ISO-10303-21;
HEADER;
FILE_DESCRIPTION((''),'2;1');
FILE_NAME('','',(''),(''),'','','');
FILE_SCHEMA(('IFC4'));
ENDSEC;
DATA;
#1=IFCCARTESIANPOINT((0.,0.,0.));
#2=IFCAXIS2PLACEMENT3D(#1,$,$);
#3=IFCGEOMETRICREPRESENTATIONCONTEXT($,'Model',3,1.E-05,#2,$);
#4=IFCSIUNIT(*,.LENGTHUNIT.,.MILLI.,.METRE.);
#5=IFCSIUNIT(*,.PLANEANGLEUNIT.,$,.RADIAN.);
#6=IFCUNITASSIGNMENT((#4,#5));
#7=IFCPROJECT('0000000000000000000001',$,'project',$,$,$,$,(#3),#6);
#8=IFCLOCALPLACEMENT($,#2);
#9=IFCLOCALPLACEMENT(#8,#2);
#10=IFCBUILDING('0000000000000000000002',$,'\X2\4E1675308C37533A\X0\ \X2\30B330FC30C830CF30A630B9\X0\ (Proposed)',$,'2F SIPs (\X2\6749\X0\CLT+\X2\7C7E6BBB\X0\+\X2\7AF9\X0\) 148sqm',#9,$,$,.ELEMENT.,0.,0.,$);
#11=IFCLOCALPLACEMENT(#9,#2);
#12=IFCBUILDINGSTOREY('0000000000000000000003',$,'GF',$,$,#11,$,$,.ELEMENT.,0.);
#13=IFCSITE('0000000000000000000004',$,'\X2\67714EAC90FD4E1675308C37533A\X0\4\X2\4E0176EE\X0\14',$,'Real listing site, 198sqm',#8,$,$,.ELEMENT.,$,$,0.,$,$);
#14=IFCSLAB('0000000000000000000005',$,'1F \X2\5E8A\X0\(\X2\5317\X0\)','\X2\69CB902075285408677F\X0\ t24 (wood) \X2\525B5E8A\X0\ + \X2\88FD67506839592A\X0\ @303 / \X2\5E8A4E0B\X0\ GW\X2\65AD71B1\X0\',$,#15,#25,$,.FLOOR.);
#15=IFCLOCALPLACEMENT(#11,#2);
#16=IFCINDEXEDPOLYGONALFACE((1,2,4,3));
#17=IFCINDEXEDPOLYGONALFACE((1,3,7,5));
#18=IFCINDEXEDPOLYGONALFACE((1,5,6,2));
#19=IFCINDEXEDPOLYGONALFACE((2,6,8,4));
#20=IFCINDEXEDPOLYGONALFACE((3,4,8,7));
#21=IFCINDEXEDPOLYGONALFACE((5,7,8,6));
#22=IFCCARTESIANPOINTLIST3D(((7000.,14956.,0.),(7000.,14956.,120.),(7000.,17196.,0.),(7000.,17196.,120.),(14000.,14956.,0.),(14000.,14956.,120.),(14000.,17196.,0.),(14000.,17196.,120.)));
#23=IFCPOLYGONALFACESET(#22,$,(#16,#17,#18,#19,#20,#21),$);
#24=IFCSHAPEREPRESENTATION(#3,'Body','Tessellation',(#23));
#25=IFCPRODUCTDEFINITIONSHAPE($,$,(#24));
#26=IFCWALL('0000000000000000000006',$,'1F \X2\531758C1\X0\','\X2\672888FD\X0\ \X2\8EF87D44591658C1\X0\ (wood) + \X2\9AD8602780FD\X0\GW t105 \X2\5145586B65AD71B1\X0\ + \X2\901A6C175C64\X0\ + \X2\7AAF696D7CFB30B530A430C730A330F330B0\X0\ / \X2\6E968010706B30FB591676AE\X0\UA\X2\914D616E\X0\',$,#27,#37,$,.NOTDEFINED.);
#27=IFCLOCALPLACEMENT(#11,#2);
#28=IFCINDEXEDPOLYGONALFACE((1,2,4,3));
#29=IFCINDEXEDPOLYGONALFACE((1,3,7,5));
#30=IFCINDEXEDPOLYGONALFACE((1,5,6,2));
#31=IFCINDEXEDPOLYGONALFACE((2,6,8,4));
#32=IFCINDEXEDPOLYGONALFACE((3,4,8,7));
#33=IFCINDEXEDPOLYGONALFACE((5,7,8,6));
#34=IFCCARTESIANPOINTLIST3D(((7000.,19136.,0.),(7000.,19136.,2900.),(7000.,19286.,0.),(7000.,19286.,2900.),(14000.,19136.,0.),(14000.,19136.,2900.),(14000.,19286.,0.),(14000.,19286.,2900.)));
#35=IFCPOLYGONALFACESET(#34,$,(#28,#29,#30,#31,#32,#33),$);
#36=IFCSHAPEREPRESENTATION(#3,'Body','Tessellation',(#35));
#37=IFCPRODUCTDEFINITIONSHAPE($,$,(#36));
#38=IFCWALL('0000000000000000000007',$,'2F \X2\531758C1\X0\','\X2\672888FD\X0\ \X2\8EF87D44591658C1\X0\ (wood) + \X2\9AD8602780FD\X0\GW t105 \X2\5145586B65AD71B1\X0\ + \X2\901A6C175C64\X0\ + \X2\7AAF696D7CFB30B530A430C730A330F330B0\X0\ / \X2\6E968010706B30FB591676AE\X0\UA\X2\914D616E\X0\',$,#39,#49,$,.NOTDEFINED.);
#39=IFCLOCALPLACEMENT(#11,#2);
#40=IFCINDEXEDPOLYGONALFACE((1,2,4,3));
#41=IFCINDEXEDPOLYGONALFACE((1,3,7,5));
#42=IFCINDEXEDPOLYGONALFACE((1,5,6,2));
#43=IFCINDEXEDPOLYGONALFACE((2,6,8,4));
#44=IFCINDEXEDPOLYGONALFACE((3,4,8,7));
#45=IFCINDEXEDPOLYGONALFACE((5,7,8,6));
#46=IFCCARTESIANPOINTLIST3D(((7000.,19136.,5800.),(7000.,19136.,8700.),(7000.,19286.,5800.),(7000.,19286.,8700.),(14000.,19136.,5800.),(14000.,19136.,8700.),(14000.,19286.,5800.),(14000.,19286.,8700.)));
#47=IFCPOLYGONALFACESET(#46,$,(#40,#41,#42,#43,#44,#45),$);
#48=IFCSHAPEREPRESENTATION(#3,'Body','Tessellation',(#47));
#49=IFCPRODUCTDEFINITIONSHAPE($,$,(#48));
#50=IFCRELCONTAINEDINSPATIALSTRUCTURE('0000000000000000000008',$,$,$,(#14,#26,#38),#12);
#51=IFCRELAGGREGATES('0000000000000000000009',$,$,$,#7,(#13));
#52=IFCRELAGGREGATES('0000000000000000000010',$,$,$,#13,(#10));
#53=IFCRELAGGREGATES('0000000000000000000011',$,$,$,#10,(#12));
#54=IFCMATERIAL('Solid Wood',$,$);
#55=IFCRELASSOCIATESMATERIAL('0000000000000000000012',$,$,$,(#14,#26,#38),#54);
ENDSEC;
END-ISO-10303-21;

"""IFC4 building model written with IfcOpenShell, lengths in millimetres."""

from ifc_helpers import new_model, si_unit, frame, frame_2d, origin, place, context, project, spatial, rectangle, extrude, material, element, save


model = new_model("IFC4")

# Units and contexts
model_context = context("Model", 3, precision=1e-05, world=origin())
ifc_project = project(units=[si_unit("LENGTHUNIT", "METRE", prefix="MILLI"), si_unit("PLANEANGLEUNIT", "RADIAN")], contexts=[model_context])

# Site, building, storey
site_placement = place(None, origin())
site = spatial("IfcSite", under=ifc_project, at=site_placement, Name="東京都世田谷区4丁目14", ObjectType="Real listing site, 198sqm", CompositionType="ELEMENT", RefElevation=0.0)
building_placement = place(site_placement, origin())
building = spatial("IfcBuilding", under=site, at=building_placement, Name="世田谷区 コートハウス (Proposed)", ObjectType="2F SIPs (杉CLT+籾殻+竹) 148sqm", CompositionType="ELEMENT", ElevationOfRefHeight=0.0, ElevationOfTerrain=0.0)
storey_placement = place(building_placement, origin())
storey = spatial("IfcBuildingStorey", under=building, at=storey_placement, Name="GF", CompositionType="ELEMENT", Elevation=0.0)

# Slab
ifc_material_1 = material(Name="Solid Wood")
slab_1_placement = place(storey_placement, frame((3500.0, 7478.0, 0.0)))
element("IfcSlab", 1, at=slab_1_placement, inside=storey, material=ifc_material_1, Name="1F 床(北)", Description="構造用合板 t24 (wood) 剛床 + 製材根太 @303 / 床下 GW断熱", PredefinedType="FLOOR", context=model_context, shape_type="SweptSolid", body=[
    extrude(rectangle(XDim=7000.0, YDim=2240.0, at=frame_2d((3500.0, 1120.0))), frame((3500.0, 7478.0, 0.0)), (0.0, 0.0, 1.0), 120.0),
])

# Wall
wall_1_placement = place(storey_placement, frame((3500.0, 9568.0, 0.0)))
element("IfcWall", 2, at=wall_1_placement, inside=storey, material=ifc_material_1, Name="1F 北壁", Description="木製 軸組外壁 (wood) + 高性能GW t105 充填断熱 + 通気層 + 窯業系サイディング / 準耐火・外皮UA配慮", PredefinedType="NOTDEFINED", context=model_context, shape_type="SweptSolid", body=[
    extrude(rectangle(XDim=7000.0, YDim=150.0, at=frame_2d((3500.0, 75.0))), frame((3500.0, 9568.0, 0.0)), (0.0, 0.0, 1.0), 2900.0),
])

# Wall
wall_2_placement = place(storey_placement, frame((3500.0, 9568.0, 2900.0)))
element("IfcWall", 3, at=wall_2_placement, inside=storey, material=ifc_material_1, Name="2F 北壁", Description="木製 軸組外壁 (wood) + 高性能GW t105 充填断熱 + 通気層 + 窯業系サイディング / 準耐火・外皮UA配慮", PredefinedType="NOTDEFINED", context=model_context, shape_type="SweptSolid", body=[
    extrude(rectangle(XDim=7000.0, YDim=150.0, at=frame_2d((3500.0, 75.0))), frame((3500.0, 9568.0, 2900.0)), (0.0, 0.0, 1.0), 2900.0),
])

save(model, "model.ifc")
